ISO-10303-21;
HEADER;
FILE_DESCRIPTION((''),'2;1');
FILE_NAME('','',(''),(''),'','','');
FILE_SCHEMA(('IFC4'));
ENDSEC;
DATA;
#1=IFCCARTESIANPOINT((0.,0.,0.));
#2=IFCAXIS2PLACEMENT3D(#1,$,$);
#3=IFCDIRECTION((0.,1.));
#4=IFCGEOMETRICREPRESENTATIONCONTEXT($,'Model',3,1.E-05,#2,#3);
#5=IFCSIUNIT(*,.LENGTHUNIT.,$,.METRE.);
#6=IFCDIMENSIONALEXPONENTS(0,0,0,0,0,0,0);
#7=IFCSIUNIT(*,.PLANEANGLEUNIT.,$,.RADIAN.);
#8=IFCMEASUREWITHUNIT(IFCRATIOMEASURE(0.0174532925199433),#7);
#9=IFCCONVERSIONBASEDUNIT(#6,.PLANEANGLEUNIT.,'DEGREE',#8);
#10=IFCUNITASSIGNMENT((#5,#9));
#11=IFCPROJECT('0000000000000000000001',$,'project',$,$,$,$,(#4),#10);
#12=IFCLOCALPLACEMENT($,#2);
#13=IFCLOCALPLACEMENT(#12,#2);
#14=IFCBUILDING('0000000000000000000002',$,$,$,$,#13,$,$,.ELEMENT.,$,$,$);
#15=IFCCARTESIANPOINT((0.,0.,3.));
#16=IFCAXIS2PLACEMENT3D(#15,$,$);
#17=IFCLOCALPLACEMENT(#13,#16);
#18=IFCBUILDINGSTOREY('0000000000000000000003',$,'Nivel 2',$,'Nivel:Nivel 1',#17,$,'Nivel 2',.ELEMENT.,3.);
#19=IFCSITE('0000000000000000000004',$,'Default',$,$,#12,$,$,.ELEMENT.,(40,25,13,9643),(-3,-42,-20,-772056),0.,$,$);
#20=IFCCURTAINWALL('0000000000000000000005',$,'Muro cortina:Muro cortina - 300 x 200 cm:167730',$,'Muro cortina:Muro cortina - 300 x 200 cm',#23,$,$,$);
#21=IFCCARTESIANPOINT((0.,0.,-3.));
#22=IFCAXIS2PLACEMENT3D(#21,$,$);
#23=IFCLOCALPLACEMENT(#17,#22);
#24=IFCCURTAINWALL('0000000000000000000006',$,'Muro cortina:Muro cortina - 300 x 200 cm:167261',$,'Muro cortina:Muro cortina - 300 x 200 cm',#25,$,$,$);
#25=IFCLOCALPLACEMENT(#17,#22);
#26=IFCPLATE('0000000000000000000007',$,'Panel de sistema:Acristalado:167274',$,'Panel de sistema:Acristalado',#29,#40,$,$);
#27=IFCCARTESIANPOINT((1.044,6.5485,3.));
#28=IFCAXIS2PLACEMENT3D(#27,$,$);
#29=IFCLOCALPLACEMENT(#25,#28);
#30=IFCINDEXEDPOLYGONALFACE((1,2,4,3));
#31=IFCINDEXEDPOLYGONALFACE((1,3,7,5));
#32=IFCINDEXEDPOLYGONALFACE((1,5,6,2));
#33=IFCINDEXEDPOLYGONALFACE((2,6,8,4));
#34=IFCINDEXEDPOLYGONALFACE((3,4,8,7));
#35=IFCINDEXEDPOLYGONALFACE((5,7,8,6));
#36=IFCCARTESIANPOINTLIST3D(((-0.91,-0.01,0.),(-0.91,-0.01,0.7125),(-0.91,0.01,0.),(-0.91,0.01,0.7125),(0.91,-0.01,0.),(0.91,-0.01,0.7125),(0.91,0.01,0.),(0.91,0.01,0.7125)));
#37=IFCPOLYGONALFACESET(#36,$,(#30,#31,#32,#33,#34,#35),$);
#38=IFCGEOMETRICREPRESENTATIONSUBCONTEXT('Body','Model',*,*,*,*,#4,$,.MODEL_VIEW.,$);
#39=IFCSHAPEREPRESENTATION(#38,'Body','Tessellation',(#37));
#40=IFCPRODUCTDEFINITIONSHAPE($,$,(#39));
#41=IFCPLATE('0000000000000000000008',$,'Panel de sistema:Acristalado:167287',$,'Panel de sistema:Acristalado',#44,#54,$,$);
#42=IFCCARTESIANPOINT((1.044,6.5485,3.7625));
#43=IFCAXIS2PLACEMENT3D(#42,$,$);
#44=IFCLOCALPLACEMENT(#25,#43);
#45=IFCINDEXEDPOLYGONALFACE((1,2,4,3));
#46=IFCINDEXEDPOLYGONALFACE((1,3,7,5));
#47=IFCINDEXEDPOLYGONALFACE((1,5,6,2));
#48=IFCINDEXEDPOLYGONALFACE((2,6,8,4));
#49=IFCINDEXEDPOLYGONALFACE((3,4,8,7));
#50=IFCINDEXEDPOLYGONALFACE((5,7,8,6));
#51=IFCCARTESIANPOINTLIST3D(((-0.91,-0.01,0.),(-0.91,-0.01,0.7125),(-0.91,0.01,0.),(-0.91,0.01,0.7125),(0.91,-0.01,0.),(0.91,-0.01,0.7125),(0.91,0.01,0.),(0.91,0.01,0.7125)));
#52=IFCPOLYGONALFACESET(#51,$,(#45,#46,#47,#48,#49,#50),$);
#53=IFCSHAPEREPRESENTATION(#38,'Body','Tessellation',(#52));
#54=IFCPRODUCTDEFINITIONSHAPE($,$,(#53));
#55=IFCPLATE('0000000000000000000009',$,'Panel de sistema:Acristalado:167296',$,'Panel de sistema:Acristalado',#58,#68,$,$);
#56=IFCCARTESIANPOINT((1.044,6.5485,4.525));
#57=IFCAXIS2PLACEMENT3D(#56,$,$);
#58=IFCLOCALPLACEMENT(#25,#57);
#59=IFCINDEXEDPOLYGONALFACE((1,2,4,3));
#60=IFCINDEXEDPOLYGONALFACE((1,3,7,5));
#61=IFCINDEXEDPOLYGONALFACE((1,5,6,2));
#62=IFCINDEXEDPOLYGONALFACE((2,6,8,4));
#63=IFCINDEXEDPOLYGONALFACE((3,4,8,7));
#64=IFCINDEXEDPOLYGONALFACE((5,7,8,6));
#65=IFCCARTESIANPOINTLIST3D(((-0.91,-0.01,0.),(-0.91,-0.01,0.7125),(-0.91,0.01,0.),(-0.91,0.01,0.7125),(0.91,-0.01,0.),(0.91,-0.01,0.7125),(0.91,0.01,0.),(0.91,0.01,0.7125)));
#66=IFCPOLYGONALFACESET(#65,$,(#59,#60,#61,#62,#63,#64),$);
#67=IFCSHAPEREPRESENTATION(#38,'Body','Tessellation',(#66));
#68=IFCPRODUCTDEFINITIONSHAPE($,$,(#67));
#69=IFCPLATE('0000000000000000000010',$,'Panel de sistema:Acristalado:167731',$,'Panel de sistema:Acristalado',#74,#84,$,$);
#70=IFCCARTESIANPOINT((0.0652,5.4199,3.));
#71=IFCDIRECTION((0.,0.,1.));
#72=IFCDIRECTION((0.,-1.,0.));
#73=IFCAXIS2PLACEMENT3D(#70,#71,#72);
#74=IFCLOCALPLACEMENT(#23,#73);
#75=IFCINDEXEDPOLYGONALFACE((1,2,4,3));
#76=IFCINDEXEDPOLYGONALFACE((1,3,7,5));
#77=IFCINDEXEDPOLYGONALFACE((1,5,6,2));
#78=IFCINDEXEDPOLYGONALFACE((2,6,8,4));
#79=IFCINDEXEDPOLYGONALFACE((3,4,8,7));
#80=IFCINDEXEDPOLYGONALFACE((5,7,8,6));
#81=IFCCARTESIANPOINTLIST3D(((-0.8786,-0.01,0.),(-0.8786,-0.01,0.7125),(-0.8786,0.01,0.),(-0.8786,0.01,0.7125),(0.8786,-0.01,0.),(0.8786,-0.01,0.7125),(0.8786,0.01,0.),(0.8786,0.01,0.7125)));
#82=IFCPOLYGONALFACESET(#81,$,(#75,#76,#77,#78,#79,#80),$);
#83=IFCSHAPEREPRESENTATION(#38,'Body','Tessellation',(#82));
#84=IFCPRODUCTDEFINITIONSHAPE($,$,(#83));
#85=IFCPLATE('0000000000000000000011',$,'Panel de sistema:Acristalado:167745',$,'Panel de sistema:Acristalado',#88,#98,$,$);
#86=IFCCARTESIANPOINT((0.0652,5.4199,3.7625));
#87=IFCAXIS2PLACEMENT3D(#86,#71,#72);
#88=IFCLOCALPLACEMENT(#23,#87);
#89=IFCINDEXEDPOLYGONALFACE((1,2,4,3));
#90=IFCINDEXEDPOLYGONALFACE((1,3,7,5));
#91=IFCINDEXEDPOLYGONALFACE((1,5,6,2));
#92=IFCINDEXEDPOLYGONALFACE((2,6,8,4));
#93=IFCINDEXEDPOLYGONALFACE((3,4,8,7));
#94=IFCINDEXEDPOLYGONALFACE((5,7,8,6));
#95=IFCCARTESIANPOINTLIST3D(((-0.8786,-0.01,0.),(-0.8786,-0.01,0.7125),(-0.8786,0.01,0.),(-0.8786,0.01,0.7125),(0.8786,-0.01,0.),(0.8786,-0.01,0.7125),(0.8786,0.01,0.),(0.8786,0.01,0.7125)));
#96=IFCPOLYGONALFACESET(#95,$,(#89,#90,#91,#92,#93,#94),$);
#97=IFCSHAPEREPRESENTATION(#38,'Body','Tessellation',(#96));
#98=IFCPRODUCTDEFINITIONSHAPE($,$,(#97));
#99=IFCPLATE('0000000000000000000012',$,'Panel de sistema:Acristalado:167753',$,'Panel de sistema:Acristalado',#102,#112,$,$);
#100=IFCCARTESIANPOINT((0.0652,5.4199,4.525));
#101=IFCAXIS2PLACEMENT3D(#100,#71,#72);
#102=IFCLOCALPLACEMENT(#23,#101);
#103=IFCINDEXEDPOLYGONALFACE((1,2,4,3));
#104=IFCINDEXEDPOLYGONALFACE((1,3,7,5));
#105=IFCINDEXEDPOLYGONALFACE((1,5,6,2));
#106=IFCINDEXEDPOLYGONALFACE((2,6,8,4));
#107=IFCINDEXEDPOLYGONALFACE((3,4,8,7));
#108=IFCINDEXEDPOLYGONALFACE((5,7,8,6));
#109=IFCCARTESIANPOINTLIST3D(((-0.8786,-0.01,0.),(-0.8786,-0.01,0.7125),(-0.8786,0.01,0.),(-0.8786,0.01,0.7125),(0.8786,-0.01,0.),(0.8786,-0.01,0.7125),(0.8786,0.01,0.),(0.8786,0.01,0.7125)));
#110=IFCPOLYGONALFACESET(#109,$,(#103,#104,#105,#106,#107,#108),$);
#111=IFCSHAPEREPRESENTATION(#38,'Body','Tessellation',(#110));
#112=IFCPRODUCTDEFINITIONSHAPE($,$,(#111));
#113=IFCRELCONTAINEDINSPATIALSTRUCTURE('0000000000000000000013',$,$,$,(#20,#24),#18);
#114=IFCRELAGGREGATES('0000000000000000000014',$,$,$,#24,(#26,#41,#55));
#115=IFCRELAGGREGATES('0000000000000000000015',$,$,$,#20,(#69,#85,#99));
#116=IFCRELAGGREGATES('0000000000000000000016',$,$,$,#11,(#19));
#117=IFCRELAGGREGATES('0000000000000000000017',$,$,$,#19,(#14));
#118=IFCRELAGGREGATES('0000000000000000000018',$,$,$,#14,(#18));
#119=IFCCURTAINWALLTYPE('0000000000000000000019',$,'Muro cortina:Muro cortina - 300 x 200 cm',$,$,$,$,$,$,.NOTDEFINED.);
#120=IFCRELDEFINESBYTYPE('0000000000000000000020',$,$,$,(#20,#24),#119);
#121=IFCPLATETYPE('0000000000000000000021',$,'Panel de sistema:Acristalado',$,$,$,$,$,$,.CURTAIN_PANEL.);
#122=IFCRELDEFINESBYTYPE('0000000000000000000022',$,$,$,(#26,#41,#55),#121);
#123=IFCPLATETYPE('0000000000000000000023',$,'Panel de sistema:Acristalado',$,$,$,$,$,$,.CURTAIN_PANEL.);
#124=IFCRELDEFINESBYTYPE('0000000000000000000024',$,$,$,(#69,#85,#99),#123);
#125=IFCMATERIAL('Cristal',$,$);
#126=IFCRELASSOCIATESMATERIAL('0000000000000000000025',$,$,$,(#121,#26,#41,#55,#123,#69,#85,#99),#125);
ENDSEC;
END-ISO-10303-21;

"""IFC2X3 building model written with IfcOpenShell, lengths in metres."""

from ifc_helpers import new_model, entity, si_unit, converted_unit, direction, frame, origin, origin_2d_with_axis, place, context, subcontext, project, spatial, rectangle, extrude, source, transform, mapped, material, type_object, type_shapes, element, aggregate, save


model = new_model("IFC2X3")

# Units and contexts
model_context = context("Model", 3, precision=1e-05, world=origin(), true_north=direction((0.0, 1.0)))
body_context = subcontext(model_context, "Body", "Model", "MODEL_VIEW")
ifc_project = project(units=[si_unit("LENGTHUNIT", "METRE"), converted_unit("PLANEANGLEUNIT", "DEGREE", entity("IfcRatioMeasure", 0.0174532925199433), si_unit("PLANEANGLEUNIT", "RADIAN"), dimensions=[0, 0, 0, 0, 0, 0, 0])], contexts=[model_context])

# Site, building, storey
site_placement = place(None, origin())
site = spatial("IfcSite", under=ifc_project, at=site_placement, Name="Default", CompositionType="ELEMENT", RefLatitude=(40, 25, 13, 9643), RefLongitude=(-3, -42, -20, -772056), RefElevation=0.0)
building_placement = place(site_placement, origin())
building = spatial("IfcBuilding", under=site, at=building_placement, CompositionType="ELEMENT")
storey_placement = place(building_placement, frame((0.0, 0.0, 3.0)))
storey = spatial("IfcBuildingStorey", under=building, at=storey_placement, Name="Nivel 2", ObjectType="Nivel:Nivel 1", LongName="Nivel 2", CompositionType="ELEMENT", Elevation=3.0)

# Curtain walls
curtain_wall_type = type_object("IfcCurtainWallType", Name="Muro cortina:Muro cortina - 300 x 200 cm", PredefinedType="NOTDEFINED")
curtain_wall_1_placement = place(storey_placement, frame((0.0, 0.0, -3.0)))
curtain_wall_1 = element("IfcCurtainWall", 1, at=curtain_wall_1_placement, inside=storey, type_object=curtain_wall_type, Name="Muro cortina:Muro cortina - 300 x 200 cm:167730", ObjectType="Muro cortina:Muro cortina - 300 x 200 cm")
curtain_wall_2_placement = place(storey_placement, frame((0.0, 0.0, -3.0)))
curtain_wall_2 = element("IfcCurtainWall", 2, at=curtain_wall_2_placement, inside=storey, type_object=curtain_wall_type, Name="Muro cortina:Muro cortina - 300 x 200 cm:167261", ObjectType="Muro cortina:Muro cortina - 300 x 200 cm")

# Plates
ifc_material_1 = material(Name="Cristal")
plate_type_1 = type_object("IfcPlateType", Name="Panel de sistema:Acristalado", PredefinedType="CURTAIN_PANEL", material=ifc_material_1)
shared_shape_1 = source(origin(), body_context, "Body", "SweptSolid", [
    extrude(rectangle(XDim=0.02, YDim=1.82, at=origin_2d_with_axis()), frame((0.0, 0.0, 0.0), z_axis=(0.0, 0.0, 1.0), x_axis=(0.0, 1.0, 0.0)), (0.0, 0.0, 1.0), 0.7125),
])
type_shapes(plate_type_1, [shared_shape_1])
plate_1_placement = place(curtain_wall_2_placement, frame((1.044, 6.5485, 3.0)))
plate_1 = element("IfcPlate", 3, at=plate_1_placement, type_object=plate_type_1, material=ifc_material_1, Name="Panel de sistema:Acristalado:167274", ObjectType="Panel de sistema:Acristalado", context=body_context, shape_type="MappedRepresentation", body=[
    mapped(shared_shape_1, transform((0.0, 0.0, 0.0), scale=1.0)),
])
plate_2_placement = place(curtain_wall_2_placement, frame((1.044, 6.5485, 3.7625)))
plate_2 = element("IfcPlate", 4, at=plate_2_placement, type_object=plate_type_1, material=ifc_material_1, Name="Panel de sistema:Acristalado:167287", ObjectType="Panel de sistema:Acristalado", context=body_context, shape_type="MappedRepresentation", body=[
    mapped(shared_shape_1, transform((0.0, 0.0, 0.0), scale=1.0)),
])
plate_3_placement = place(curtain_wall_2_placement, frame((1.044, 6.5485, 4.525)))
plate_3 = element("IfcPlate", 5, at=plate_3_placement, type_object=plate_type_1, material=ifc_material_1, Name="Panel de sistema:Acristalado:167296", ObjectType="Panel de sistema:Acristalado", context=body_context, shape_type="MappedRepresentation", body=[
    mapped(shared_shape_1, transform((0.0, 0.0, 0.0), scale=1.0)),
])
aggregate(curtain_wall_2, [plate_1, plate_2, plate_3])
plate_type_2 = type_object("IfcPlateType", Name="Panel de sistema:Acristalado", PredefinedType="CURTAIN_PANEL", material=ifc_material_1)
shared_shape_2 = source(origin(), body_context, "Body", "SweptSolid", [
    extrude(rectangle(XDim=0.02, YDim=1.7571, at=origin_2d_with_axis()), frame((0.0, 0.0, 0.0), z_axis=(0.0, 0.0, 1.0), x_axis=(0.0, 1.0, 0.0)), (0.0, 0.0, 1.0), 0.7125),
])
type_shapes(plate_type_2, [shared_shape_2])
plate_4_placement = place(curtain_wall_1_placement, frame((0.0652, 5.4199, 3.0), z_axis=(0.0, 0.0, 1.0), x_axis=(0.0, -1.0, 0.0)))
plate_4 = element("IfcPlate", 6, at=plate_4_placement, type_object=plate_type_2, material=ifc_material_1, Name="Panel de sistema:Acristalado:167731", ObjectType="Panel de sistema:Acristalado", context=body_context, shape_type="MappedRepresentation", body=[
    mapped(shared_shape_2, transform((0.0, 0.0, 0.0), scale=1.0)),
])
plate_5_placement = place(curtain_wall_1_placement, frame((0.0652, 5.4199, 3.7625), z_axis=(0.0, 0.0, 1.0), x_axis=(0.0, -1.0, 0.0)))
plate_5 = element("IfcPlate", 7, at=plate_5_placement, type_object=plate_type_2, material=ifc_material_1, Name="Panel de sistema:Acristalado:167745", ObjectType="Panel de sistema:Acristalado", context=body_context, shape_type="MappedRepresentation", body=[
    mapped(shared_shape_2, transform((0.0, 0.0, 0.0), scale=1.0)),
])
plate_6_placement = place(curtain_wall_1_placement, frame((0.0652, 5.4199, 4.525), z_axis=(0.0, 0.0, 1.0), x_axis=(0.0, -1.0, 0.0)))
plate_6 = element("IfcPlate", 8, at=plate_6_placement, type_object=plate_type_2, material=ifc_material_1, Name="Panel de sistema:Acristalado:167753", ObjectType="Panel de sistema:Acristalado", context=body_context, shape_type="MappedRepresentation", body=[
    mapped(shared_shape_2, transform((0.0, 0.0, 0.0), scale=1.0)),
])
aggregate(curtain_wall_1, [plate_4, plate_5, plate_6])

save(model, "model.ifc")
